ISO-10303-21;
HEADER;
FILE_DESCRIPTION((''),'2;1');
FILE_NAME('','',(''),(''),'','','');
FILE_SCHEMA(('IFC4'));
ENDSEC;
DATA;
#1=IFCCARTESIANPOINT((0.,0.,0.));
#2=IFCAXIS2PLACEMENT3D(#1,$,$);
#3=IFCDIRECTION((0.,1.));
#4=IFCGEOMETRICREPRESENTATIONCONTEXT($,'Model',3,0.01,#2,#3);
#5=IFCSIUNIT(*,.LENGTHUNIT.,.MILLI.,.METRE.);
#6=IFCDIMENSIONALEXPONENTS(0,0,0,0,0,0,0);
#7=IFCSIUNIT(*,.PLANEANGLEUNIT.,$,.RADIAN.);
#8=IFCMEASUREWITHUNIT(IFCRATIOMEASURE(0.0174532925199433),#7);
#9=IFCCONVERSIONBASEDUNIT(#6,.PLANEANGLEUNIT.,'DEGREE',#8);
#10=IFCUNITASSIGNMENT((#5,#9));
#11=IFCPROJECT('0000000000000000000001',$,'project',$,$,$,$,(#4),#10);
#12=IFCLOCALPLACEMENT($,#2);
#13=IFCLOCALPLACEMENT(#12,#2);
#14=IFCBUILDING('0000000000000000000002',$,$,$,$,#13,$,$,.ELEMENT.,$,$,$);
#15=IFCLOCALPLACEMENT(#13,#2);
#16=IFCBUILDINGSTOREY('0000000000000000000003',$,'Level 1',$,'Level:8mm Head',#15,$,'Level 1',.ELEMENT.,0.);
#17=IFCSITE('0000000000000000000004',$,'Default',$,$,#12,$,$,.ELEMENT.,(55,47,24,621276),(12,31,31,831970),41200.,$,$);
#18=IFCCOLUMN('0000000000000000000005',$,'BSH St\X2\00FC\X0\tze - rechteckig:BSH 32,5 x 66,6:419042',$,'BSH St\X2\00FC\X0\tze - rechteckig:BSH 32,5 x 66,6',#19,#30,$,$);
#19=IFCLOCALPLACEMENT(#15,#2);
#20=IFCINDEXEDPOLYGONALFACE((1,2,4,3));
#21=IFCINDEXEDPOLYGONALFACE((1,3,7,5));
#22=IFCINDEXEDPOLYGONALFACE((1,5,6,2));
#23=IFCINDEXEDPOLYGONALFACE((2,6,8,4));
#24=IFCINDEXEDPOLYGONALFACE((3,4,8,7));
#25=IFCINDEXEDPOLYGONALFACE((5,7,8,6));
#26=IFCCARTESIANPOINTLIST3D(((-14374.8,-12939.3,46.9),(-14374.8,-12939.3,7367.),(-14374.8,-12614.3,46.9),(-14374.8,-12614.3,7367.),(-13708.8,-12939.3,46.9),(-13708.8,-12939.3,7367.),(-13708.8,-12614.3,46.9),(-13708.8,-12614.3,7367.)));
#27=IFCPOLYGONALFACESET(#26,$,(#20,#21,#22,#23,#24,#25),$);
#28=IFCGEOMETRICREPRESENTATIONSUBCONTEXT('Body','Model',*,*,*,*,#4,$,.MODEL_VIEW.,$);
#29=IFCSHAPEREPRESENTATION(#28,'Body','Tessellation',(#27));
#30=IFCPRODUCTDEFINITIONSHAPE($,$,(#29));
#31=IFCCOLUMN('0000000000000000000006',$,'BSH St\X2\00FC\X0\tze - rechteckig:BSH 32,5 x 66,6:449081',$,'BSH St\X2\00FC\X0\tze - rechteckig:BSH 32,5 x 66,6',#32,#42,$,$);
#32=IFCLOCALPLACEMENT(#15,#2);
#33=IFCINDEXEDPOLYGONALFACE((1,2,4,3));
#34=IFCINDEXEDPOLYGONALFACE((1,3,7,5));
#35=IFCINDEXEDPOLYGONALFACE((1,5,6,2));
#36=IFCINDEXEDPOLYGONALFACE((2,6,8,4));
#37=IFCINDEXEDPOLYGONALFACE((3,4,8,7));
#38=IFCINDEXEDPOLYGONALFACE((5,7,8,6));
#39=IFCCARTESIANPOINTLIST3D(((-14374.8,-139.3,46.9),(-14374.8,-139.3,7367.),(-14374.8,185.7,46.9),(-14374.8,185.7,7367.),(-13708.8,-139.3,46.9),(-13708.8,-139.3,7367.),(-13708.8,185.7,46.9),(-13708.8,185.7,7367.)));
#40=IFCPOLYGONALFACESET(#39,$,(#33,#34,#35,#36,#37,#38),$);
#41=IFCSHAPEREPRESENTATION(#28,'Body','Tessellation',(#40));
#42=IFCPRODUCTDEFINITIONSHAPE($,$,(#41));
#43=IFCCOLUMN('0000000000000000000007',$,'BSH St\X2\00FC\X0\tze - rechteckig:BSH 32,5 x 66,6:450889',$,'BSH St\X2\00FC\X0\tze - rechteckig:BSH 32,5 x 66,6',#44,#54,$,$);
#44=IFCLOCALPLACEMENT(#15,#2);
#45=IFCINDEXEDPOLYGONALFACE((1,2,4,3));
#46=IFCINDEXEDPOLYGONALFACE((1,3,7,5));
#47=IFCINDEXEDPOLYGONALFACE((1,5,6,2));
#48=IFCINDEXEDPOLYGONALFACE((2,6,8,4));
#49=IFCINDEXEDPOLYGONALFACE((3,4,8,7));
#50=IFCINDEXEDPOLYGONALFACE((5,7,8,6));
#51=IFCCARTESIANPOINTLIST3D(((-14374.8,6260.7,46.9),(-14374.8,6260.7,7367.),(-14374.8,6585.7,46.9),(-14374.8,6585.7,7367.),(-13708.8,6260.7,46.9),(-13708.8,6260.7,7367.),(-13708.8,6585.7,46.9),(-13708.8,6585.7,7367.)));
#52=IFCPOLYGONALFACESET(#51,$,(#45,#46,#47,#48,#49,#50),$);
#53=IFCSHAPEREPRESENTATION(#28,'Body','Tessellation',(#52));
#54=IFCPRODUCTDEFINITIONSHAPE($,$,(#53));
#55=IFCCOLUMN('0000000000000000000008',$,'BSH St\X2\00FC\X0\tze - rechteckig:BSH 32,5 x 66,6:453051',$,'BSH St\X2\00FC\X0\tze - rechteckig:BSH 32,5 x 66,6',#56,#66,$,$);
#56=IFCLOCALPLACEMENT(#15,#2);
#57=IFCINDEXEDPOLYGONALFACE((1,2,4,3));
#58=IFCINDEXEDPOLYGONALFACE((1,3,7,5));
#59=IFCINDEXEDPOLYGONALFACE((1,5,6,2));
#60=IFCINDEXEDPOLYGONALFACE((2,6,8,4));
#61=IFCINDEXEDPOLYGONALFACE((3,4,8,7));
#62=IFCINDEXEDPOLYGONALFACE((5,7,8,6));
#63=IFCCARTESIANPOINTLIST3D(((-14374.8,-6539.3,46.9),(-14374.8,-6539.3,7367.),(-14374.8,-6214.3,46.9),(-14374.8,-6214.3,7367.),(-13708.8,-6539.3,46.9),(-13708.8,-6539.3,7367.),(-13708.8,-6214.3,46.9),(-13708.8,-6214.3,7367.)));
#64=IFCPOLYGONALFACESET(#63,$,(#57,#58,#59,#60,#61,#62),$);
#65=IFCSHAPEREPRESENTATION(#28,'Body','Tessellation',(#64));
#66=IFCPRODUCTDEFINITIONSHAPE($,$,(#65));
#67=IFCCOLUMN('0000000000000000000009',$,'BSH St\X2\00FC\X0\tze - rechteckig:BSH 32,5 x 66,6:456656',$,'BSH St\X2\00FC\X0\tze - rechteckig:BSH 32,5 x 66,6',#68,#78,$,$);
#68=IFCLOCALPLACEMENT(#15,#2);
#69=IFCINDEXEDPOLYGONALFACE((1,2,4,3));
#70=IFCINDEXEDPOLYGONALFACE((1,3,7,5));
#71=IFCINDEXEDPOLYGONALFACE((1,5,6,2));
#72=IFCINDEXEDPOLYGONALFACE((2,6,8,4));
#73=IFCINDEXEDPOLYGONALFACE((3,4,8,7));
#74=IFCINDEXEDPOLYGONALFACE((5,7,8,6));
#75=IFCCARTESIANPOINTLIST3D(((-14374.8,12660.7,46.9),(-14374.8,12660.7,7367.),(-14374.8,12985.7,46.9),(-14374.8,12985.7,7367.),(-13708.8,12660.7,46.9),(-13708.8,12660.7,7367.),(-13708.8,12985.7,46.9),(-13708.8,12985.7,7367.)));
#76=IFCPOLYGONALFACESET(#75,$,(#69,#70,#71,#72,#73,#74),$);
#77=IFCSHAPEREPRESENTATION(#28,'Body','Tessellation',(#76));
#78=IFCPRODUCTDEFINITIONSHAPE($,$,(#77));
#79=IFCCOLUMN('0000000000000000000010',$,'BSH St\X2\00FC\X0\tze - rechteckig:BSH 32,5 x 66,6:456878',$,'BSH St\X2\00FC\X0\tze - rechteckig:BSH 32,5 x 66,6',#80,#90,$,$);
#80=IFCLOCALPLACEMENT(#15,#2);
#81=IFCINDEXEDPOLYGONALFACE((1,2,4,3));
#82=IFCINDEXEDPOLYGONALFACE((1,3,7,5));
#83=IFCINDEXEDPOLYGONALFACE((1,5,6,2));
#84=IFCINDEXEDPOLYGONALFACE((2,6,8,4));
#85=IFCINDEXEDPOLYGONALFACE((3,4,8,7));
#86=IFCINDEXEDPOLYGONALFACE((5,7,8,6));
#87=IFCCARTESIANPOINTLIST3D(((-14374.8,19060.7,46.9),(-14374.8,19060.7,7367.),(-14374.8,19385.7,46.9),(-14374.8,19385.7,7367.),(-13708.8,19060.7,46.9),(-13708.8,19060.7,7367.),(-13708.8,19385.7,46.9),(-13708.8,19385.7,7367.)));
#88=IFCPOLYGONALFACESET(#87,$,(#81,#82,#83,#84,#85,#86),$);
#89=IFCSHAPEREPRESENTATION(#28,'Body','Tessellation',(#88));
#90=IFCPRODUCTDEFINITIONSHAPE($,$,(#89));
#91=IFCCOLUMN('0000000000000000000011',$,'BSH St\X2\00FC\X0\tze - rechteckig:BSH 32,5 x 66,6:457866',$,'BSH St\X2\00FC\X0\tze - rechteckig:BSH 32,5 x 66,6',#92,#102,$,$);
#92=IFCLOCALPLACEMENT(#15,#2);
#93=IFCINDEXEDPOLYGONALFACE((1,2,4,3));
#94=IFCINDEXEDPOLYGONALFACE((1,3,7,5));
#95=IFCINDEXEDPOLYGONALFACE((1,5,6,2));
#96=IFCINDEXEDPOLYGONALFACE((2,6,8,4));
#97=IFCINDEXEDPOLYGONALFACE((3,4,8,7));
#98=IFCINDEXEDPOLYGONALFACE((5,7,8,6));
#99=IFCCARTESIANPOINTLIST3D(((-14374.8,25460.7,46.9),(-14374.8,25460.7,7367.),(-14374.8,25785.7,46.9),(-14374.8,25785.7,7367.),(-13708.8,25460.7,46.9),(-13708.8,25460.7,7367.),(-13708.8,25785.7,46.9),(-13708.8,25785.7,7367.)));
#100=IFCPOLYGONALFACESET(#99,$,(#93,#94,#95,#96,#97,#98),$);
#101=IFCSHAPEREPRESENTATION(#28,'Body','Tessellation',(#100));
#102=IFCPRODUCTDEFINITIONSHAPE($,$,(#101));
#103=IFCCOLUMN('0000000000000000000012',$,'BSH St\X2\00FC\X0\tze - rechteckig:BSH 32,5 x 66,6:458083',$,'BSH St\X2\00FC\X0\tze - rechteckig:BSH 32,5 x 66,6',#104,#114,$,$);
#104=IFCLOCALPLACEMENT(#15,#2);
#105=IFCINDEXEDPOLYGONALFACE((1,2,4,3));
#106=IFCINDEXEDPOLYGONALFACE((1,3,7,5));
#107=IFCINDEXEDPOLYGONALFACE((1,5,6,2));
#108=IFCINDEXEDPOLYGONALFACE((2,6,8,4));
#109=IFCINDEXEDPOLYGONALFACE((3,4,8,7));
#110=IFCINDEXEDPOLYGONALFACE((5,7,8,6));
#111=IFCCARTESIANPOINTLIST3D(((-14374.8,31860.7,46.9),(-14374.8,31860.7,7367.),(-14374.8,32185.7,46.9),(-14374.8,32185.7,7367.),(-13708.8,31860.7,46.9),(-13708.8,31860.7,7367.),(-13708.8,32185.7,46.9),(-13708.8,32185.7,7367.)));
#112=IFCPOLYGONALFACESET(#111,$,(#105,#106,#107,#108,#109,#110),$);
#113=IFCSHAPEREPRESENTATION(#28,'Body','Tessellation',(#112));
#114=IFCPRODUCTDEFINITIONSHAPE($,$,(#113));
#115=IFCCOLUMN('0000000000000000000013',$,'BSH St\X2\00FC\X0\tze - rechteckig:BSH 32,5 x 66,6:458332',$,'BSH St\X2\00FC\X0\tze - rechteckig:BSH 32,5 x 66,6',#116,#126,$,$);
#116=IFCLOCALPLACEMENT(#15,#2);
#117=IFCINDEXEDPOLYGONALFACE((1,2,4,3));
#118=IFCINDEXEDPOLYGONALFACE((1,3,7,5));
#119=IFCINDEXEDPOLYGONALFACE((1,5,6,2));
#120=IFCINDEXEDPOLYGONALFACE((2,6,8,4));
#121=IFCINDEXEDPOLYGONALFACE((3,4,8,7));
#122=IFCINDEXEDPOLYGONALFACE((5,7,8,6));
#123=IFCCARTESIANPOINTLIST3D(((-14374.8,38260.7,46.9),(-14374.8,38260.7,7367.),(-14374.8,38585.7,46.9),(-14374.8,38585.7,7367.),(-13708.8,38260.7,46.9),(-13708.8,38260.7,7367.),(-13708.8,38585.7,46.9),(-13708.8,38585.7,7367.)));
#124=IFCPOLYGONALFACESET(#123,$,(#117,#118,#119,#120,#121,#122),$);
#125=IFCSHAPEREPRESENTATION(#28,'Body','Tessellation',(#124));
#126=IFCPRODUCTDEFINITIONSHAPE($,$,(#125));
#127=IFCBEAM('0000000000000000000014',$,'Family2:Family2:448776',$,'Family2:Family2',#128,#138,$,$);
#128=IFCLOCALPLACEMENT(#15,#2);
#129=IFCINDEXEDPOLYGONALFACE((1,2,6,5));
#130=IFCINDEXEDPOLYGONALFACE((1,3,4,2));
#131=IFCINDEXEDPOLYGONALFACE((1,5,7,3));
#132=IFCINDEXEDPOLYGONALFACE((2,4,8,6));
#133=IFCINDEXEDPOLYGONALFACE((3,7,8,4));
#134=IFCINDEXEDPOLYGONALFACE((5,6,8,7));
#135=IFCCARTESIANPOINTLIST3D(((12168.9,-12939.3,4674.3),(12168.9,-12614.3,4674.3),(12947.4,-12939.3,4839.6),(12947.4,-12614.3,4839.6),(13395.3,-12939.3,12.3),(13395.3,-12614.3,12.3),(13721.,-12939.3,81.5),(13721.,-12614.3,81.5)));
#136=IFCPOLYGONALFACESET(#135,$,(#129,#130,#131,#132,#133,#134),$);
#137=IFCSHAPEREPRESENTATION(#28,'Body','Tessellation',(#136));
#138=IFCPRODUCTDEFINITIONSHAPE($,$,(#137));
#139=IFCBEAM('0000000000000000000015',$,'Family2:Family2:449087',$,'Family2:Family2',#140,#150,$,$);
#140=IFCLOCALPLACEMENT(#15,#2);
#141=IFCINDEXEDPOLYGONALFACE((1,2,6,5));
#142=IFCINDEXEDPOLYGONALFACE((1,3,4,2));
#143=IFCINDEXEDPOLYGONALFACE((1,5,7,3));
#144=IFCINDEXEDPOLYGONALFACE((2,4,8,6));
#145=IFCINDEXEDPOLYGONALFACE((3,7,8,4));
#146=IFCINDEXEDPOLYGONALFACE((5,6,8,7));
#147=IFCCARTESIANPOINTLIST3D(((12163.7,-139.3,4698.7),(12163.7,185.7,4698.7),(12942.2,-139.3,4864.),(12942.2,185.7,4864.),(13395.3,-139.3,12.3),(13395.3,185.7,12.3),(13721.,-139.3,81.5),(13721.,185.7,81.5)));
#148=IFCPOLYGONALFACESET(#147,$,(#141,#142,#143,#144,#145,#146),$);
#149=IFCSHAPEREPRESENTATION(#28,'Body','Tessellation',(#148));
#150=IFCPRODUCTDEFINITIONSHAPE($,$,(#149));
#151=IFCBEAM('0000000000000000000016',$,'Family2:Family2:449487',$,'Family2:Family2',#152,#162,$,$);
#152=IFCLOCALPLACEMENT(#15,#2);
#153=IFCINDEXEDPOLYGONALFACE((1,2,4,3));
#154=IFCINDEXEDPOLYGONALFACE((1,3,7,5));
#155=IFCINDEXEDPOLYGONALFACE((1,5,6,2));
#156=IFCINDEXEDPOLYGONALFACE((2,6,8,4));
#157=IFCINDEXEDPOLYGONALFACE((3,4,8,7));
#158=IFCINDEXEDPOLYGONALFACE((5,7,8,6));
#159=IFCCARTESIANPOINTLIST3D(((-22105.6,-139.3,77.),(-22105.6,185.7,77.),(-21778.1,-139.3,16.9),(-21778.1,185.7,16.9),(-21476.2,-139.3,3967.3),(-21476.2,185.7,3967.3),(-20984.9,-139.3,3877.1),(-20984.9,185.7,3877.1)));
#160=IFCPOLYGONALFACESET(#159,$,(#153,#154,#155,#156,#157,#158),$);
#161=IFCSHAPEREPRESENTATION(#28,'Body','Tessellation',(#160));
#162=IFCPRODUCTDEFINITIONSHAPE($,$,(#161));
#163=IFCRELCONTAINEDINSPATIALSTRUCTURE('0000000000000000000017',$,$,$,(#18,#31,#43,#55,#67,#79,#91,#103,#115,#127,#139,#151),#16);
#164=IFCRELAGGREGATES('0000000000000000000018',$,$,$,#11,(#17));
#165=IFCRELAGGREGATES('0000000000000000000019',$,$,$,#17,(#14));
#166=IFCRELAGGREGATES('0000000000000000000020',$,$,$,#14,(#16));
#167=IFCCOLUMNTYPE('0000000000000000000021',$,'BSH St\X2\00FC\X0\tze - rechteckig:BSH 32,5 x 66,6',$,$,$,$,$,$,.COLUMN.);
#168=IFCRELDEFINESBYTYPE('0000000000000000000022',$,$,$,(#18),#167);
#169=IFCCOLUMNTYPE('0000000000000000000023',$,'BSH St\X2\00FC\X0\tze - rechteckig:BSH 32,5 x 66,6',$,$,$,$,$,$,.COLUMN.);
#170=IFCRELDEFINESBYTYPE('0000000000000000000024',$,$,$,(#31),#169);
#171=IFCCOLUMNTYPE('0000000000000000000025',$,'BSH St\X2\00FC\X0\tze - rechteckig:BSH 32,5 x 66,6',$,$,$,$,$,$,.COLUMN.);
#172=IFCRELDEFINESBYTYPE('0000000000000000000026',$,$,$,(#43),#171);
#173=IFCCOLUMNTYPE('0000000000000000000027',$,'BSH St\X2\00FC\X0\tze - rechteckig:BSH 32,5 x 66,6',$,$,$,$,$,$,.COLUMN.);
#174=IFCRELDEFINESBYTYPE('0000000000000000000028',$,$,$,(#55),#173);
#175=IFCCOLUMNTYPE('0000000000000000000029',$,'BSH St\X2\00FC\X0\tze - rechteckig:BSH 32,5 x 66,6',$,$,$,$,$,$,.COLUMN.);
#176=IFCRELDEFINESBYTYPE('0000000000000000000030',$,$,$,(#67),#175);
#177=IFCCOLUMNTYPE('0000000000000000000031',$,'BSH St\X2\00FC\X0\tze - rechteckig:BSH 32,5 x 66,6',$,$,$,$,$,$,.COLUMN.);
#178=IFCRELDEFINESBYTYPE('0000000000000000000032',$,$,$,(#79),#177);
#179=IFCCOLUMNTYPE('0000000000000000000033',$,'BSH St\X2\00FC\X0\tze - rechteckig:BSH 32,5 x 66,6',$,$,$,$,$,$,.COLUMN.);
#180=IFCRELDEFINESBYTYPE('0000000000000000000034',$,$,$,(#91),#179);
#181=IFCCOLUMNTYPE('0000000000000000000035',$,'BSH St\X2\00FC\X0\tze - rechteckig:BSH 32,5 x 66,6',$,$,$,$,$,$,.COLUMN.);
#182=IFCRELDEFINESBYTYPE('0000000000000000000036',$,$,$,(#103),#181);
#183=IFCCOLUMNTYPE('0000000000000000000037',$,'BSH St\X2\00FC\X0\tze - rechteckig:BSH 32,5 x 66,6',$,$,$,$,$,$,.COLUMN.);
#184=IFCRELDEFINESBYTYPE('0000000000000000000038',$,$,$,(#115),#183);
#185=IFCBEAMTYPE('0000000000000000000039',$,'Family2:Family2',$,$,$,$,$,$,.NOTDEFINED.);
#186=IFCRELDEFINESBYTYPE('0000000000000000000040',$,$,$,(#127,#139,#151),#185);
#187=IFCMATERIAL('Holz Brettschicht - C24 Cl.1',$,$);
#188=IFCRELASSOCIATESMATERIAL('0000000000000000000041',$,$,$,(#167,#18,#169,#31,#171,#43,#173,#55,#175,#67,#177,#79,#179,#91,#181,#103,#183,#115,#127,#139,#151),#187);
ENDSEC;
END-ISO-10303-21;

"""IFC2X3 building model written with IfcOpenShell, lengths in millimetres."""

from ifc_helpers import new_model, entity, si_unit, converted_unit, direction, frame, frame_2d, origin, place, context, subcontext, project, spatial, rectangle, extrude, clip, halfspace, source, transform, mapped, material, type_object, type_shapes, element, save


model = new_model("IFC2X3")

# Units and contexts
model_context = context("Model", 3, precision=0.01, world=origin(), true_north=direction((0.0, 1.0)))
body_context = subcontext(model_context, "Body", "Model", "MODEL_VIEW")
ifc_project = project(units=[si_unit("LENGTHUNIT", "METRE", prefix="MILLI"), converted_unit("PLANEANGLEUNIT", "DEGREE", entity("IfcRatioMeasure", 0.0174532925199433), si_unit("PLANEANGLEUNIT", "RADIAN"), dimensions=[0, 0, 0, 0, 0, 0, 0])], contexts=[model_context])

# Site, building, storey
site_placement = place(None, origin())
site = spatial("IfcSite", under=ifc_project, at=site_placement, Name="Default", CompositionType="ELEMENT", RefLatitude=(55, 47, 24, 621276), RefLongitude=(12, 31, 31, 831970), RefElevation=41200.0)
building_placement = place(site_placement, origin())
building = spatial("IfcBuilding", under=site, at=building_placement, CompositionType="ELEMENT")
storey_placement = place(building_placement, origin())
storey = spatial("IfcBuildingStorey", under=building, at=storey_placement, Name="Level 1", ObjectType="Level:8mm Head", LongName="Level 1", CompositionType="ELEMENT", Elevation=0.0)

# Columns
ifc_material_1 = material(Name="Holz Brettschicht - C24 Cl.1")
column_type_1 = type_object("IfcColumnType", Name="BSH Stütze - rechteckig:BSH 32,5 x 66,6", PredefinedType="COLUMN", material=ifc_material_1)
shared_shape_1 = source(origin(), body_context, "Body", "SweptSolid", [
    extrude(rectangle(XDim=325.0, YDim=666.0, at=frame_2d((0.0, 0.0), x_axis=(1.0, 0.0))), frame((-14041.8, -12776.8, 46.9), z_axis=(0.0, 0.0, 1.0), x_axis=(0.0, -1.0, 0.0)), (0.0, 0.0, 1.0), 7320.1),
])
type_shapes(column_type_1, [shared_shape_1])
column_1_placement = place(storey_placement, origin())
element("IfcColumn", 1, at=column_1_placement, inside=storey, type_object=column_type_1, material=ifc_material_1, Name="BSH Stütze - rechteckig:BSH 32,5 x 66,6:419042", ObjectType="BSH Stütze - rechteckig:BSH 32,5 x 66,6", context=body_context, shape_type="MappedRepresentation", body=[
    mapped(shared_shape_1, transform((0.0, 0.0, 0.0), scale=1.0)),
])
column_type_2 = type_object("IfcColumnType", Name="BSH Stütze - rechteckig:BSH 32,5 x 66,6", PredefinedType="COLUMN", material=ifc_material_1)
shared_shape_2 = source(origin(), body_context, "Body", "SweptSolid", [
    extrude(rectangle(XDim=325.0, YDim=666.0, at=frame_2d((0.0, 0.0), x_axis=(1.0, 0.0))), frame((-14041.8, 23.2, 46.9), z_axis=(0.0, 0.0, 1.0), x_axis=(0.0, -1.0, 0.0)), (0.0, 0.0, 1.0), 7320.1),
])
type_shapes(column_type_2, [shared_shape_2])
column_2_placement = place(storey_placement, origin())
element("IfcColumn", 2, at=column_2_placement, inside=storey, type_object=column_type_2, material=ifc_material_1, Name="BSH Stütze - rechteckig:BSH 32,5 x 66,6:449081", ObjectType="BSH Stütze - rechteckig:BSH 32,5 x 66,6", context=body_context, shape_type="MappedRepresentation", body=[
    mapped(shared_shape_2, transform((0.0, 0.0, 0.0), scale=1.0)),
])
column_type_3 = type_object("IfcColumnType", Name="BSH Stütze - rechteckig:BSH 32,5 x 66,6", PredefinedType="COLUMN", material=ifc_material_1)
shared_shape_3 = source(origin(), body_context, "Body", "SweptSolid", [
    extrude(rectangle(XDim=325.0, YDim=666.0, at=frame_2d((0.0, 0.0), x_axis=(1.0, 0.0))), frame((-14041.8, 6423.2, 46.9), z_axis=(0.0, 0.0, 1.0), x_axis=(0.0, -1.0, 0.0)), (0.0, 0.0, 1.0), 7320.1),
])
type_shapes(column_type_3, [shared_shape_3])
column_3_placement = place(storey_placement, origin())
element("IfcColumn", 3, at=column_3_placement, inside=storey, type_object=column_type_3, material=ifc_material_1, Name="BSH Stütze - rechteckig:BSH 32,5 x 66,6:450889", ObjectType="BSH Stütze - rechteckig:BSH 32,5 x 66,6", context=body_context, shape_type="MappedRepresentation", body=[
    mapped(shared_shape_3, transform((0.0, 0.0, 0.0), scale=1.0)),
])
column_type_4 = type_object("IfcColumnType", Name="BSH Stütze - rechteckig:BSH 32,5 x 66,6", PredefinedType="COLUMN", material=ifc_material_1)
shared_shape_4 = source(origin(), body_context, "Body", "SweptSolid", [
    extrude(rectangle(XDim=325.0, YDim=666.0, at=frame_2d((0.0, 0.0), x_axis=(1.0, 0.0))), frame((-14041.8, -6376.8, 46.9), z_axis=(0.0, 0.0, 1.0), x_axis=(0.0, -1.0, 0.0)), (0.0, 0.0, 1.0), 7320.1),
])
type_shapes(column_type_4, [shared_shape_4])
column_4_placement = place(storey_placement, origin())
element("IfcColumn", 4, at=column_4_placement, inside=storey, type_object=column_type_4, material=ifc_material_1, Name="BSH Stütze - rechteckig:BSH 32,5 x 66,6:453051", ObjectType="BSH Stütze - rechteckig:BSH 32,5 x 66,6", context=body_context, shape_type="MappedRepresentation", body=[
    mapped(shared_shape_4, transform((0.0, 0.0, 0.0), scale=1.0)),
])
column_type_5 = type_object("IfcColumnType", Name="BSH Stütze - rechteckig:BSH 32,5 x 66,6", PredefinedType="COLUMN", material=ifc_material_1)
shared_shape_5 = source(origin(), body_context, "Body", "SweptSolid", [
    extrude(rectangle(XDim=325.0, YDim=666.0, at=frame_2d((0.0, 0.0), x_axis=(1.0, 0.0))), frame((-14041.8, 12823.2, 46.9), z_axis=(0.0, 0.0, 1.0), x_axis=(0.0, -1.0, 0.0)), (0.0, 0.0, 1.0), 7320.1),
])
type_shapes(column_type_5, [shared_shape_5])
column_5_placement = place(storey_placement, origin())
element("IfcColumn", 5, at=column_5_placement, inside=storey, type_object=column_type_5, material=ifc_material_1, Name="BSH Stütze - rechteckig:BSH 32,5 x 66,6:456656", ObjectType="BSH Stütze - rechteckig:BSH 32,5 x 66,6", context=body_context, shape_type="MappedRepresentation", body=[
    mapped(shared_shape_5, transform((0.0, 0.0, 0.0), scale=1.0)),
])
column_type_6 = type_object("IfcColumnType", Name="BSH Stütze - rechteckig:BSH 32,5 x 66,6", PredefinedType="COLUMN", material=ifc_material_1)
shared_shape_6 = source(origin(), body_context, "Body", "SweptSolid", [
    extrude(rectangle(XDim=325.0, YDim=666.0, at=frame_2d((0.0, 0.0), x_axis=(1.0, 0.0))), frame((-14041.8, 19223.2, 46.9), z_axis=(0.0, 0.0, 1.0), x_axis=(0.0, -1.0, 0.0)), (0.0, 0.0, 1.0), 7320.1),
])
type_shapes(column_type_6, [shared_shape_6])
column_6_placement = place(storey_placement, origin())
element("IfcColumn", 6, at=column_6_placement, inside=storey, type_object=column_type_6, material=ifc_material_1, Name="BSH Stütze - rechteckig:BSH 32,5 x 66,6:456878", ObjectType="BSH Stütze - rechteckig:BSH 32,5 x 66,6", context=body_context, shape_type="MappedRepresentation", body=[
    mapped(shared_shape_6, transform((0.0, 0.0, 0.0), scale=1.0)),
])
column_type_7 = type_object("IfcColumnType", Name="BSH Stütze - rechteckig:BSH 32,5 x 66,6", PredefinedType="COLUMN", material=ifc_material_1)
shared_shape_7 = source(origin(), body_context, "Body", "SweptSolid", [
    extrude(rectangle(XDim=325.0, YDim=666.0, at=frame_2d((0.0, 0.0), x_axis=(1.0, 0.0))), frame((-14041.8, 25623.2, 46.9), z_axis=(0.0, 0.0, 1.0), x_axis=(0.0, -1.0, 0.0)), (0.0, 0.0, 1.0), 7320.1),
])
type_shapes(column_type_7, [shared_shape_7])
column_7_placement = place(storey_placement, origin())
element("IfcColumn", 7, at=column_7_placement, inside=storey, type_object=column_type_7, material=ifc_material_1, Name="BSH Stütze - rechteckig:BSH 32,5 x 66,6:457866", ObjectType="BSH Stütze - rechteckig:BSH 32,5 x 66,6", context=body_context, shape_type="MappedRepresentation", body=[
    mapped(shared_shape_7, transform((0.0, 0.0, 0.0), scale=1.0)),
])
column_type_8 = type_object("IfcColumnType", Name="BSH Stütze - rechteckig:BSH 32,5 x 66,6", PredefinedType="COLUMN", material=ifc_material_1)
shared_shape_8 = source(origin(), body_context, "Body", "SweptSolid", [
    extrude(rectangle(XDim=325.0, YDim=666.0, at=frame_2d((0.0, 0.0), x_axis=(1.0, 0.0))), frame((-14041.8, 32023.2, 46.9), z_axis=(0.0, 0.0, 1.0), x_axis=(0.0, -1.0, 0.0)), (0.0, 0.0, 1.0), 7320.1),
])
type_shapes(column_type_8, [shared_shape_8])
column_8_placement = place(storey_placement, origin())
element("IfcColumn", 8, at=column_8_placement, inside=storey, type_object=column_type_8, material=ifc_material_1, Name="BSH Stütze - rechteckig:BSH 32,5 x 66,6:458083", ObjectType="BSH Stütze - rechteckig:BSH 32,5 x 66,6", context=body_context, shape_type="MappedRepresentation", body=[
    mapped(shared_shape_8, transform((0.0, 0.0, 0.0), scale=1.0)),
])
column_type_9 = type_object("IfcColumnType", Name="BSH Stütze - rechteckig:BSH 32,5 x 66,6", PredefinedType="COLUMN", material=ifc_material_1)
shared_shape_9 = source(origin(), body_context, "Body", "SweptSolid", [
    extrude(rectangle(XDim=325.0, YDim=666.0, at=frame_2d((0.0, 0.0), x_axis=(1.0, 0.0))), frame((-14041.8, 38423.2, 46.9), z_axis=(0.0, 0.0, 1.0), x_axis=(0.0, -1.0, 0.0)), (0.0, 0.0, 1.0), 7320.1),
])
type_shapes(column_type_9, [shared_shape_9])
column_9_placement = place(storey_placement, origin())
element("IfcColumn", 9, at=column_9_placement, inside=storey, type_object=column_type_9, material=ifc_material_1, Name="BSH Stütze - rechteckig:BSH 32,5 x 66,6:458332", ObjectType="BSH Stütze - rechteckig:BSH 32,5 x 66,6", context=body_context, shape_type="MappedRepresentation", body=[
    mapped(shared_shape_9, transform((0.0, 0.0, 0.0), scale=1.0)),
])

# Beams
beam_type_1 = type_object("IfcBeamType", Name="Family2:Family2", PredefinedType="NOTDEFINED")
beam_1_placement = place(storey_placement, frame((12558.2, -12776.8, 4756.9), z_axis=(0.978196, 0.0, 0.207685), x_axis=(0.207685, 0.0, -0.978196)))
element("IfcBeam", 10, at=beam_1_placement, inside=storey, type_object=beam_type_1, material=ifc_material_1, Name="Family2:Family2:448776", ObjectType="Family2:Family2", context=body_context, shape_type="Clipping", body=[
    clip(clip(extrude(rectangle(XDim=795.9, YDim=325.0, at=frame_2d((0.0, 0.0), x_axis=(0.0, 1.0))), frame((0.0, 0.0, 0.0), z_axis=(1.0, 0.0, 0.0), x_axis=(0.0, 1.0, 0.0)), (0.0, 0.0, 1.0), 4815.0), halfspace(frame((0.0, 0.0, -397.9), z_axis=(0.048013, 0.0, -0.998847), x_axis=(0.0, 1.0, 0.0)), False)), halfspace(frame((0.0, 0.0, 398.0), z_axis=(0.048013, 0.0, 0.998847), x_axis=(0.0, -1.0, 0.0)), False)),
])
beam_2_placement = place(storey_placement, frame((12553.0, 23.2, 4781.4), z_axis=(0.978196, 0.0, 0.207685), x_axis=(0.207685, 0.0, -0.978196)))
element("IfcBeam", 11, at=beam_2_placement, inside=storey, type_object=beam_type_1, material=ifc_material_1, Name="Family2:Family2:449087", ObjectType="Family2:Family2", context=body_context, shape_type="Clipping", body=[
    clip(clip(extrude(rectangle(XDim=795.9, YDim=325.0, at=frame_2d((0.0, 0.0), x_axis=(0.0, 1.0))), frame((0.0, 0.0, 0.0), z_axis=(1.0, 0.0, 0.0), x_axis=(0.0, 1.0, 0.0)), (0.0, 0.0, 1.0), 4840.0), halfspace(frame((0.0, 0.0, -397.9), z_axis=(0.047766, 0.0, -0.998859), x_axis=(0.0, 1.0, 0.0)), False)), halfspace(frame((0.0, 0.0, 398.0), z_axis=(0.047766, 0.0, 0.998859), x_axis=(0.0, -1.0, 0.0)), False)),
])
beam_3_placement = place(storey_placement, frame((-21941.8, 23.2, 46.9), z_axis=(0.983571, 0.0, -0.180519), x_axis=(0.180519, 0.0, 0.983571)))
element("IfcBeam", 12, at=beam_3_placement, inside=storey, type_object=beam_type_1, material=ifc_material_1, Name="Family2:Family2:449487", ObjectType="Family2:Family2", context=body_context, shape_type="Clipping", body=[
    clip(clip(extrude(rectangle(XDim=499.5, YDim=325.0, at=frame_2d((0.0, 0.0), x_axis=(0.0, 1.0))), frame((0.0, 0.0, 0.0), z_axis=(1.0, 0.0, 0.0), x_axis=(0.0, 1.0, 0.0)), (0.0, 0.0, 1.0), 3940.0), halfspace(frame((0.0, 0.0, 166.5), z_axis=(-0.021125, 0.0, 0.999777), x_axis=(0.0, -1.0, 0.0)), False)), halfspace(frame((0.0, 0.0, -166.5), z_axis=(-0.021125, 0.0, -0.999777), x_axis=(0.0, 1.0, 0.0)), False)),
])

save(model, "model.ifc")
